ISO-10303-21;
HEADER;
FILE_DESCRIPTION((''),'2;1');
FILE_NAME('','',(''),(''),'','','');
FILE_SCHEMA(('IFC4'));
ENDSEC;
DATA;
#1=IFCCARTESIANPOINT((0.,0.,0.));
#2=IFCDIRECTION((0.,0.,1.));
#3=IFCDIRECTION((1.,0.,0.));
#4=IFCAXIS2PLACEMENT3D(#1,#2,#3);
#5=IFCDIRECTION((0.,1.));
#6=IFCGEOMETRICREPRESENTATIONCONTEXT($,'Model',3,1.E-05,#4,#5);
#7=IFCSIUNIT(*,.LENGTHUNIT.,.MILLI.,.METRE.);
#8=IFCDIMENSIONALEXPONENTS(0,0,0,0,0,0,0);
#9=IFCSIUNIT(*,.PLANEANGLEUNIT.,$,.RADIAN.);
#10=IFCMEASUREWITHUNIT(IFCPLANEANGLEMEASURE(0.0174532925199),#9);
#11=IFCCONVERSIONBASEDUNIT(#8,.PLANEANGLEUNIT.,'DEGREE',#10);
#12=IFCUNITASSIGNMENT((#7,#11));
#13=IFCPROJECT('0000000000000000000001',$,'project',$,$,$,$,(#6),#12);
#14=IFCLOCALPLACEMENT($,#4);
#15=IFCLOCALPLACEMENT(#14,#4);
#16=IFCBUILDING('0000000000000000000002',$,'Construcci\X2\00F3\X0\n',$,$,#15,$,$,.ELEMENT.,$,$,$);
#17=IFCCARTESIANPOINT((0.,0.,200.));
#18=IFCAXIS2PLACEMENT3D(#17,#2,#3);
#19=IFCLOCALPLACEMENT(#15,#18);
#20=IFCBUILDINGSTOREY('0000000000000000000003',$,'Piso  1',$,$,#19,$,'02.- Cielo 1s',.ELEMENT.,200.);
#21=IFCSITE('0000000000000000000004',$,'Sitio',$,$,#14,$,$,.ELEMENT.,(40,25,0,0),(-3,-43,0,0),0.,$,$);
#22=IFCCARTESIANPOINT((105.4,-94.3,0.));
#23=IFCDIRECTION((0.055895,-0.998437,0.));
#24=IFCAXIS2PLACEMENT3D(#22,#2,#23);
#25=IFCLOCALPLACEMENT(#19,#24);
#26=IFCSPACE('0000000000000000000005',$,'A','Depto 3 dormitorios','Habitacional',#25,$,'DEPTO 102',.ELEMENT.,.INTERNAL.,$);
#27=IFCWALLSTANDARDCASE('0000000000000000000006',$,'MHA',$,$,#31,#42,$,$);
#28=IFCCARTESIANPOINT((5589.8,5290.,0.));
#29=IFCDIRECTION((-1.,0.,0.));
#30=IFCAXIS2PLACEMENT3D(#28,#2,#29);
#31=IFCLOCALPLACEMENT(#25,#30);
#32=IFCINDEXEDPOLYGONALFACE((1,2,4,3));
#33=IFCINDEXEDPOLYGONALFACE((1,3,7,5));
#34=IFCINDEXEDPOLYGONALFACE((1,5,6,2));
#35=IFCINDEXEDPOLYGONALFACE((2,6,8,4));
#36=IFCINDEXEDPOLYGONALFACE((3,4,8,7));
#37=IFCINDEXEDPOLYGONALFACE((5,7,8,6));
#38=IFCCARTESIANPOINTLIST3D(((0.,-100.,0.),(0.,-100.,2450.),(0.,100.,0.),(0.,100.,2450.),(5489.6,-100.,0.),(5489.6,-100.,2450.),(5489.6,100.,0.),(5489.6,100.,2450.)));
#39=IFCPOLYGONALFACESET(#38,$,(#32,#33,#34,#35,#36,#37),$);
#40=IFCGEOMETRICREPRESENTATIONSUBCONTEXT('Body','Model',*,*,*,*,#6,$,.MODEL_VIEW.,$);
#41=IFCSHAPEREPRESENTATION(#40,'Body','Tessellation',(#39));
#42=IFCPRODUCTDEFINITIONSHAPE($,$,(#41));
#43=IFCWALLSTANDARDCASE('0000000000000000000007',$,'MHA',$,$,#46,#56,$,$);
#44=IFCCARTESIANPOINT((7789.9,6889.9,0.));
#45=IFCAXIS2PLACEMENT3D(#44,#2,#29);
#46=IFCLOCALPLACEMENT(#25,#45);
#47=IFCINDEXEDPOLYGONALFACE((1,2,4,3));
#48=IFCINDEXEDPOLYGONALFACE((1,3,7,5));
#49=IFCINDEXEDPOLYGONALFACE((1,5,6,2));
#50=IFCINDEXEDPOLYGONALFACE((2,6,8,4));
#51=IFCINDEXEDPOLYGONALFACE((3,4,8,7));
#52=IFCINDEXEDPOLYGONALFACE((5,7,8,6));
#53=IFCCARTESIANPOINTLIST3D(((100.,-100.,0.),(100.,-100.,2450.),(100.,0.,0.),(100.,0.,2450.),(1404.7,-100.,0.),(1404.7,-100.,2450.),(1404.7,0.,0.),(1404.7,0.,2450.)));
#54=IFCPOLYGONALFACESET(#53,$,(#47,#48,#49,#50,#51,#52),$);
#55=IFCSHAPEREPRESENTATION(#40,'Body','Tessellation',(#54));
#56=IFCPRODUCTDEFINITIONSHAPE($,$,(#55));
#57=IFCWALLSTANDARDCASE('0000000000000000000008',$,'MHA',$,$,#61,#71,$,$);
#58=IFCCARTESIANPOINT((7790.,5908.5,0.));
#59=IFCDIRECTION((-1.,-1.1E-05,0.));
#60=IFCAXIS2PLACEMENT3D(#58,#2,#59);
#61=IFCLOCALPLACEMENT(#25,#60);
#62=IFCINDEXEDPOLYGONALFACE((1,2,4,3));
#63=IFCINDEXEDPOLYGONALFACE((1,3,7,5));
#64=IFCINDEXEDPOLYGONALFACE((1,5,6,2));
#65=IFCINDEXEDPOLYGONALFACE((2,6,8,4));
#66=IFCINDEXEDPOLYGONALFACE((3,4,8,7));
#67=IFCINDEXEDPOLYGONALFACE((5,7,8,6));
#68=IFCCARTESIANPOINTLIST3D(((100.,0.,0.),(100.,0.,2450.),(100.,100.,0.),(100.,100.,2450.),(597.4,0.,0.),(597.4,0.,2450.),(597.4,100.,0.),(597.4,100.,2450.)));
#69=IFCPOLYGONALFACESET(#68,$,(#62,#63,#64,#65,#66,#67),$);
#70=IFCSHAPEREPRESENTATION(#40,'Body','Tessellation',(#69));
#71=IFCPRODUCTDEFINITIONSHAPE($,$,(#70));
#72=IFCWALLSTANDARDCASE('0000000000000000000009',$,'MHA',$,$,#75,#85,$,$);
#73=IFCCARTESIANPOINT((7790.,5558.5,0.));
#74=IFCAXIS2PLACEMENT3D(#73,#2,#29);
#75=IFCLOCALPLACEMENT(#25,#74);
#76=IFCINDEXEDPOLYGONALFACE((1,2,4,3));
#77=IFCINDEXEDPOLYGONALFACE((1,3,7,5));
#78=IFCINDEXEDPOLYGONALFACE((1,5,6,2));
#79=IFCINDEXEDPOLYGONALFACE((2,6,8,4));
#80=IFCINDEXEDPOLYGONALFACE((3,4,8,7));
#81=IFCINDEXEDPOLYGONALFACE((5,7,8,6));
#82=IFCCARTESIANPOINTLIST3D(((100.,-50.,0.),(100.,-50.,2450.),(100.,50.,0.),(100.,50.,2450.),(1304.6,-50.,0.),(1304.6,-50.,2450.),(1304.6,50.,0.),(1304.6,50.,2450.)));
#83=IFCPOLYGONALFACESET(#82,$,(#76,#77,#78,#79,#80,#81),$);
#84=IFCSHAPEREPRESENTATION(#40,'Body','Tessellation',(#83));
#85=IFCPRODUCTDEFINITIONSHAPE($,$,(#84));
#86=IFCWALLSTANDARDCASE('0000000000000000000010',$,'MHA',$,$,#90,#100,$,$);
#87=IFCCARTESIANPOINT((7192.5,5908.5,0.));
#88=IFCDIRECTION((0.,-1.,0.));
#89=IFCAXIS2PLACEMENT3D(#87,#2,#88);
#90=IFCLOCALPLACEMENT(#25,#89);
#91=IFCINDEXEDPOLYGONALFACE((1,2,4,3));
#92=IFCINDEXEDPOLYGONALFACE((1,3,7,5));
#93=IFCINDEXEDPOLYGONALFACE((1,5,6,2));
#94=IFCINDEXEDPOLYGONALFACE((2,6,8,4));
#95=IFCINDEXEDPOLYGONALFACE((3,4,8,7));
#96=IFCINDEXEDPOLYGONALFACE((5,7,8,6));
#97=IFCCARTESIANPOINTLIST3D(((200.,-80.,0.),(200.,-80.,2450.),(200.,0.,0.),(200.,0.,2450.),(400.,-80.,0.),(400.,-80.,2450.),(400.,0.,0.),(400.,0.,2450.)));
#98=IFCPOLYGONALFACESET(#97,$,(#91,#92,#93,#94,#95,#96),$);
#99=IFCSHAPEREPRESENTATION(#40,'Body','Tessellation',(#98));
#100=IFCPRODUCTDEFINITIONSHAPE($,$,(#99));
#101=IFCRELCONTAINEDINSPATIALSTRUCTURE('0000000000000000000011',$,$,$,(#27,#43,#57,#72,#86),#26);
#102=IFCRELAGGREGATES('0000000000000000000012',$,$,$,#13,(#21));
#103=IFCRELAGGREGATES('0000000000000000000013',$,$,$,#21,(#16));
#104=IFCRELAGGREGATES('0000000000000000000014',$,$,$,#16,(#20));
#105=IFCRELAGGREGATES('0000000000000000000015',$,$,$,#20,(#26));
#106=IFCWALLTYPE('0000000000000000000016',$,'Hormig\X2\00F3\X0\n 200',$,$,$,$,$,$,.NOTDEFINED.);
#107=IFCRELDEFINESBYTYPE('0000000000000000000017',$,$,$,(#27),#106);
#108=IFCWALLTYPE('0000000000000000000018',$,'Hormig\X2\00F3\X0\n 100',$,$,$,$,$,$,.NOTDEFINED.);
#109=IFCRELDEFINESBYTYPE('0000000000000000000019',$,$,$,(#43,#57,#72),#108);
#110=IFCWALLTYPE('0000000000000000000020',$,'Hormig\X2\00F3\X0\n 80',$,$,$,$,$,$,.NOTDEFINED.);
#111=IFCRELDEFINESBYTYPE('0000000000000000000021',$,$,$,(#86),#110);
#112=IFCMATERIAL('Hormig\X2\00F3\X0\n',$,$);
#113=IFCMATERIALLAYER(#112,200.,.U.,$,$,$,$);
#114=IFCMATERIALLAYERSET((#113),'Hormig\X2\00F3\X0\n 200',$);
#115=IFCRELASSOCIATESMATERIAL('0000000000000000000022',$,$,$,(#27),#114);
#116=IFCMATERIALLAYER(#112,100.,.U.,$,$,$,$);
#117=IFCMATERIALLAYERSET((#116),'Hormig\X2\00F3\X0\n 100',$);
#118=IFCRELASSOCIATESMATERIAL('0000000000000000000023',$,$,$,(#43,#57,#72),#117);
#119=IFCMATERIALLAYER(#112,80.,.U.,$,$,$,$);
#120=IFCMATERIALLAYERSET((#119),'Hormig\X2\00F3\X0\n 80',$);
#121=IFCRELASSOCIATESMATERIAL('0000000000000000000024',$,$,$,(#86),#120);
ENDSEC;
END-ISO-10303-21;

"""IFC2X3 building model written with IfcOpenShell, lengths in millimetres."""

from ifc_helpers import new_model, entity, si_unit, converted_unit, direction, frame, origin_with_axes, place, context, subcontext, project, spatial, polyline, outline, extrude, material, layer, layer_set, layer_usage, type_object, element, save


model = new_model("IFC2X3")

# Units and contexts
model_context = context("Model", 3, precision=1e-05, world=origin_with_axes(), true_north=direction((0.0, 1.0)))
body_context = subcontext(model_context, "Body", "Model", "MODEL_VIEW")
ifc_project = project(units=[si_unit("LENGTHUNIT", "METRE", prefix="MILLI"), converted_unit("PLANEANGLEUNIT", "DEGREE", entity("IfcPlaneAngleMeasure", 0.0174532925199), si_unit("PLANEANGLEUNIT", "RADIAN"), dimensions=[0, 0, 0, 0, 0, 0, 0])], contexts=[model_context])

# Site, building, storey
site_placement = place(None, origin_with_axes())
site = spatial("IfcSite", under=ifc_project, at=site_placement, Name="Sitio", CompositionType="ELEMENT", RefLatitude=(40, 25, 0, 0), RefLongitude=(-3, -43, 0, 0), RefElevation=0.0)
building_placement = place(site_placement, origin_with_axes())
building = spatial("IfcBuilding", under=site, at=building_placement, Name="Construcción", CompositionType="ELEMENT")
storey_placement = place(building_placement, frame((0.0, 0.0, 200.0), z_axis=(0.0, 0.0, 1.0), x_axis=(1.0, 0.0, 0.0)))
storey = spatial("IfcBuildingStorey", under=building, at=storey_placement, Name="Piso  1", LongName="02.- Cielo 1s", CompositionType="ELEMENT", Elevation=200.0)

# Shared definitions
ifc_material = material(Name="Hormigón")

# Shared definitions
space_placement = place(storey_placement, frame((105.4, -94.3, 0.0), z_axis=(0.0, 0.0, 1.0), x_axis=(0.055895, -0.998437, 0.0)))
space = spatial("IfcSpace", under=storey, at=space_placement, Name="A", Description="Depto 3 dormitorios", ObjectType="Habitacional", LongName="DEPTO 102", CompositionType="ELEMENT", InteriorOrExteriorSpace="INTERNAL")

# Wall
ifc_layer_1 = layer(ifc_material, 200.0, ventilated="UNKNOWN")
ifc_layer_set_1 = layer_set([ifc_layer_1], Name="Hormigón 200")
ifc_layer_usage_1 = layer_usage(ifc_layer_set_1, "AXIS2", "POSITIVE", -100.0)
wall_type_1 = type_object("IfcWallType", Name="Hormigón 200", PredefinedType="NOTDEFINED")
wall_1_placement = place(space_placement, frame((5589.8, 5290.0, 0.0), z_axis=(0.0, 0.0, 1.0), x_axis=(-1.0, 0.0, 0.0)))
element("IfcWallStandardCase", 1, at=wall_1_placement, inside=space, type_object=wall_type_1, material=ifc_layer_usage_1, Name="MHA", context=body_context, shape_type="SweptSolid", body=[
    extrude(outline(polyline([(0.0, -100.0), (5489.6, -100.0), (5489.6, 100.0), (0.0, 100.0), (0.0, -100.0)])), origin_with_axes(), (0.0, 0.0, 1.0), 2450.0),
])

# Walls
ifc_layer_2 = layer(ifc_material, 100.0, ventilated="UNKNOWN")
ifc_layer_set_2 = layer_set([ifc_layer_2], Name="Hormigón 100")
ifc_layer_usage_2 = layer_usage(ifc_layer_set_2, "AXIS2", "NEGATIVE", 0.0)
wall_type_2 = type_object("IfcWallType", Name="Hormigón 100", PredefinedType="NOTDEFINED")
wall_2_placement = place(space_placement, frame((7789.9, 6889.9, 0.0), z_axis=(0.0, 0.0, 1.0), x_axis=(-1.0, 0.0, 0.0)))
element("IfcWallStandardCase", 2, at=wall_2_placement, inside=space, type_object=wall_type_2, material=ifc_layer_usage_2, Name="MHA", context=body_context, shape_type="SweptSolid", body=[
    extrude(outline(polyline([(100.0, -100.0), (1404.7, -100.0), (1404.7, 0.0), (100.0, 0.0), (100.0, -100.0)])), origin_with_axes(), (0.0, 0.0, 1.0), 2450.0),
])
ifc_layer_usage_3 = layer_usage(ifc_layer_set_2, "AXIS2", "POSITIVE", 0.0)
wall_3_placement = place(space_placement, frame((7790.0, 5908.5, 0.0), z_axis=(0.0, 0.0, 1.0), x_axis=(-1.0, -0.000011, 0.0)))
element("IfcWallStandardCase", 3, at=wall_3_placement, inside=space, type_object=wall_type_2, material=ifc_layer_usage_3, Name="MHA", context=body_context, shape_type="SweptSolid", body=[
    extrude(outline(polyline([(100.0, 0.0), (597.4, 0.0), (597.4, 100.0), (100.0, 100.0), (100.0, 0.0)])), origin_with_axes(), (0.0, 0.0, 1.0), 2450.0),
])

# Wall
ifc_layer_usage_4 = layer_usage(ifc_layer_set_2, "AXIS2", "NEGATIVE", 50.0)
wall_4_placement = place(space_placement, frame((7790.0, 5558.5, 0.0), z_axis=(0.0, 0.0, 1.0), x_axis=(-1.0, 0.0, 0.0)))
element("IfcWallStandardCase", 4, at=wall_4_placement, inside=space, type_object=wall_type_2, material=ifc_layer_usage_4, Name="MHA", context=body_context, shape_type="SweptSolid", body=[
    extrude(outline(polyline([(100.0, -50.0), (1304.6, -50.0), (1304.6, 50.0), (100.0, 50.0), (100.0, -50.0)])), origin_with_axes(), (0.0, 0.0, 1.0), 2450.0),
])

# Wall
ifc_layer_3 = layer(ifc_material, 80.0, ventilated="UNKNOWN")
ifc_layer_set_3 = layer_set([ifc_layer_3], Name="Hormigón 80")
ifc_layer_usage_5 = layer_usage(ifc_layer_set_3, "AXIS2", "POSITIVE", -80.0)
wall_type_3 = type_object("IfcWallType", Name="Hormigón 80", PredefinedType="NOTDEFINED")
wall_5_placement = place(space_placement, frame((7192.5, 5908.5, 0.0), z_axis=(0.0, 0.0, 1.0), x_axis=(0.0, -1.0, 0.0)))
element("IfcWallStandardCase", 5, at=wall_5_placement, inside=space, type_object=wall_type_3, material=ifc_layer_usage_5, Name="MHA", context=body_context, shape_type="SweptSolid", body=[
    extrude(outline(polyline([(200.0, -80.0), (400.0, -80.0), (400.0, 0.0), (200.0, 0.0), (200.0, -80.0)])), origin_with_axes(), (0.0, 0.0, 1.0), 2450.0),
])

save(model, "model.ifc")
